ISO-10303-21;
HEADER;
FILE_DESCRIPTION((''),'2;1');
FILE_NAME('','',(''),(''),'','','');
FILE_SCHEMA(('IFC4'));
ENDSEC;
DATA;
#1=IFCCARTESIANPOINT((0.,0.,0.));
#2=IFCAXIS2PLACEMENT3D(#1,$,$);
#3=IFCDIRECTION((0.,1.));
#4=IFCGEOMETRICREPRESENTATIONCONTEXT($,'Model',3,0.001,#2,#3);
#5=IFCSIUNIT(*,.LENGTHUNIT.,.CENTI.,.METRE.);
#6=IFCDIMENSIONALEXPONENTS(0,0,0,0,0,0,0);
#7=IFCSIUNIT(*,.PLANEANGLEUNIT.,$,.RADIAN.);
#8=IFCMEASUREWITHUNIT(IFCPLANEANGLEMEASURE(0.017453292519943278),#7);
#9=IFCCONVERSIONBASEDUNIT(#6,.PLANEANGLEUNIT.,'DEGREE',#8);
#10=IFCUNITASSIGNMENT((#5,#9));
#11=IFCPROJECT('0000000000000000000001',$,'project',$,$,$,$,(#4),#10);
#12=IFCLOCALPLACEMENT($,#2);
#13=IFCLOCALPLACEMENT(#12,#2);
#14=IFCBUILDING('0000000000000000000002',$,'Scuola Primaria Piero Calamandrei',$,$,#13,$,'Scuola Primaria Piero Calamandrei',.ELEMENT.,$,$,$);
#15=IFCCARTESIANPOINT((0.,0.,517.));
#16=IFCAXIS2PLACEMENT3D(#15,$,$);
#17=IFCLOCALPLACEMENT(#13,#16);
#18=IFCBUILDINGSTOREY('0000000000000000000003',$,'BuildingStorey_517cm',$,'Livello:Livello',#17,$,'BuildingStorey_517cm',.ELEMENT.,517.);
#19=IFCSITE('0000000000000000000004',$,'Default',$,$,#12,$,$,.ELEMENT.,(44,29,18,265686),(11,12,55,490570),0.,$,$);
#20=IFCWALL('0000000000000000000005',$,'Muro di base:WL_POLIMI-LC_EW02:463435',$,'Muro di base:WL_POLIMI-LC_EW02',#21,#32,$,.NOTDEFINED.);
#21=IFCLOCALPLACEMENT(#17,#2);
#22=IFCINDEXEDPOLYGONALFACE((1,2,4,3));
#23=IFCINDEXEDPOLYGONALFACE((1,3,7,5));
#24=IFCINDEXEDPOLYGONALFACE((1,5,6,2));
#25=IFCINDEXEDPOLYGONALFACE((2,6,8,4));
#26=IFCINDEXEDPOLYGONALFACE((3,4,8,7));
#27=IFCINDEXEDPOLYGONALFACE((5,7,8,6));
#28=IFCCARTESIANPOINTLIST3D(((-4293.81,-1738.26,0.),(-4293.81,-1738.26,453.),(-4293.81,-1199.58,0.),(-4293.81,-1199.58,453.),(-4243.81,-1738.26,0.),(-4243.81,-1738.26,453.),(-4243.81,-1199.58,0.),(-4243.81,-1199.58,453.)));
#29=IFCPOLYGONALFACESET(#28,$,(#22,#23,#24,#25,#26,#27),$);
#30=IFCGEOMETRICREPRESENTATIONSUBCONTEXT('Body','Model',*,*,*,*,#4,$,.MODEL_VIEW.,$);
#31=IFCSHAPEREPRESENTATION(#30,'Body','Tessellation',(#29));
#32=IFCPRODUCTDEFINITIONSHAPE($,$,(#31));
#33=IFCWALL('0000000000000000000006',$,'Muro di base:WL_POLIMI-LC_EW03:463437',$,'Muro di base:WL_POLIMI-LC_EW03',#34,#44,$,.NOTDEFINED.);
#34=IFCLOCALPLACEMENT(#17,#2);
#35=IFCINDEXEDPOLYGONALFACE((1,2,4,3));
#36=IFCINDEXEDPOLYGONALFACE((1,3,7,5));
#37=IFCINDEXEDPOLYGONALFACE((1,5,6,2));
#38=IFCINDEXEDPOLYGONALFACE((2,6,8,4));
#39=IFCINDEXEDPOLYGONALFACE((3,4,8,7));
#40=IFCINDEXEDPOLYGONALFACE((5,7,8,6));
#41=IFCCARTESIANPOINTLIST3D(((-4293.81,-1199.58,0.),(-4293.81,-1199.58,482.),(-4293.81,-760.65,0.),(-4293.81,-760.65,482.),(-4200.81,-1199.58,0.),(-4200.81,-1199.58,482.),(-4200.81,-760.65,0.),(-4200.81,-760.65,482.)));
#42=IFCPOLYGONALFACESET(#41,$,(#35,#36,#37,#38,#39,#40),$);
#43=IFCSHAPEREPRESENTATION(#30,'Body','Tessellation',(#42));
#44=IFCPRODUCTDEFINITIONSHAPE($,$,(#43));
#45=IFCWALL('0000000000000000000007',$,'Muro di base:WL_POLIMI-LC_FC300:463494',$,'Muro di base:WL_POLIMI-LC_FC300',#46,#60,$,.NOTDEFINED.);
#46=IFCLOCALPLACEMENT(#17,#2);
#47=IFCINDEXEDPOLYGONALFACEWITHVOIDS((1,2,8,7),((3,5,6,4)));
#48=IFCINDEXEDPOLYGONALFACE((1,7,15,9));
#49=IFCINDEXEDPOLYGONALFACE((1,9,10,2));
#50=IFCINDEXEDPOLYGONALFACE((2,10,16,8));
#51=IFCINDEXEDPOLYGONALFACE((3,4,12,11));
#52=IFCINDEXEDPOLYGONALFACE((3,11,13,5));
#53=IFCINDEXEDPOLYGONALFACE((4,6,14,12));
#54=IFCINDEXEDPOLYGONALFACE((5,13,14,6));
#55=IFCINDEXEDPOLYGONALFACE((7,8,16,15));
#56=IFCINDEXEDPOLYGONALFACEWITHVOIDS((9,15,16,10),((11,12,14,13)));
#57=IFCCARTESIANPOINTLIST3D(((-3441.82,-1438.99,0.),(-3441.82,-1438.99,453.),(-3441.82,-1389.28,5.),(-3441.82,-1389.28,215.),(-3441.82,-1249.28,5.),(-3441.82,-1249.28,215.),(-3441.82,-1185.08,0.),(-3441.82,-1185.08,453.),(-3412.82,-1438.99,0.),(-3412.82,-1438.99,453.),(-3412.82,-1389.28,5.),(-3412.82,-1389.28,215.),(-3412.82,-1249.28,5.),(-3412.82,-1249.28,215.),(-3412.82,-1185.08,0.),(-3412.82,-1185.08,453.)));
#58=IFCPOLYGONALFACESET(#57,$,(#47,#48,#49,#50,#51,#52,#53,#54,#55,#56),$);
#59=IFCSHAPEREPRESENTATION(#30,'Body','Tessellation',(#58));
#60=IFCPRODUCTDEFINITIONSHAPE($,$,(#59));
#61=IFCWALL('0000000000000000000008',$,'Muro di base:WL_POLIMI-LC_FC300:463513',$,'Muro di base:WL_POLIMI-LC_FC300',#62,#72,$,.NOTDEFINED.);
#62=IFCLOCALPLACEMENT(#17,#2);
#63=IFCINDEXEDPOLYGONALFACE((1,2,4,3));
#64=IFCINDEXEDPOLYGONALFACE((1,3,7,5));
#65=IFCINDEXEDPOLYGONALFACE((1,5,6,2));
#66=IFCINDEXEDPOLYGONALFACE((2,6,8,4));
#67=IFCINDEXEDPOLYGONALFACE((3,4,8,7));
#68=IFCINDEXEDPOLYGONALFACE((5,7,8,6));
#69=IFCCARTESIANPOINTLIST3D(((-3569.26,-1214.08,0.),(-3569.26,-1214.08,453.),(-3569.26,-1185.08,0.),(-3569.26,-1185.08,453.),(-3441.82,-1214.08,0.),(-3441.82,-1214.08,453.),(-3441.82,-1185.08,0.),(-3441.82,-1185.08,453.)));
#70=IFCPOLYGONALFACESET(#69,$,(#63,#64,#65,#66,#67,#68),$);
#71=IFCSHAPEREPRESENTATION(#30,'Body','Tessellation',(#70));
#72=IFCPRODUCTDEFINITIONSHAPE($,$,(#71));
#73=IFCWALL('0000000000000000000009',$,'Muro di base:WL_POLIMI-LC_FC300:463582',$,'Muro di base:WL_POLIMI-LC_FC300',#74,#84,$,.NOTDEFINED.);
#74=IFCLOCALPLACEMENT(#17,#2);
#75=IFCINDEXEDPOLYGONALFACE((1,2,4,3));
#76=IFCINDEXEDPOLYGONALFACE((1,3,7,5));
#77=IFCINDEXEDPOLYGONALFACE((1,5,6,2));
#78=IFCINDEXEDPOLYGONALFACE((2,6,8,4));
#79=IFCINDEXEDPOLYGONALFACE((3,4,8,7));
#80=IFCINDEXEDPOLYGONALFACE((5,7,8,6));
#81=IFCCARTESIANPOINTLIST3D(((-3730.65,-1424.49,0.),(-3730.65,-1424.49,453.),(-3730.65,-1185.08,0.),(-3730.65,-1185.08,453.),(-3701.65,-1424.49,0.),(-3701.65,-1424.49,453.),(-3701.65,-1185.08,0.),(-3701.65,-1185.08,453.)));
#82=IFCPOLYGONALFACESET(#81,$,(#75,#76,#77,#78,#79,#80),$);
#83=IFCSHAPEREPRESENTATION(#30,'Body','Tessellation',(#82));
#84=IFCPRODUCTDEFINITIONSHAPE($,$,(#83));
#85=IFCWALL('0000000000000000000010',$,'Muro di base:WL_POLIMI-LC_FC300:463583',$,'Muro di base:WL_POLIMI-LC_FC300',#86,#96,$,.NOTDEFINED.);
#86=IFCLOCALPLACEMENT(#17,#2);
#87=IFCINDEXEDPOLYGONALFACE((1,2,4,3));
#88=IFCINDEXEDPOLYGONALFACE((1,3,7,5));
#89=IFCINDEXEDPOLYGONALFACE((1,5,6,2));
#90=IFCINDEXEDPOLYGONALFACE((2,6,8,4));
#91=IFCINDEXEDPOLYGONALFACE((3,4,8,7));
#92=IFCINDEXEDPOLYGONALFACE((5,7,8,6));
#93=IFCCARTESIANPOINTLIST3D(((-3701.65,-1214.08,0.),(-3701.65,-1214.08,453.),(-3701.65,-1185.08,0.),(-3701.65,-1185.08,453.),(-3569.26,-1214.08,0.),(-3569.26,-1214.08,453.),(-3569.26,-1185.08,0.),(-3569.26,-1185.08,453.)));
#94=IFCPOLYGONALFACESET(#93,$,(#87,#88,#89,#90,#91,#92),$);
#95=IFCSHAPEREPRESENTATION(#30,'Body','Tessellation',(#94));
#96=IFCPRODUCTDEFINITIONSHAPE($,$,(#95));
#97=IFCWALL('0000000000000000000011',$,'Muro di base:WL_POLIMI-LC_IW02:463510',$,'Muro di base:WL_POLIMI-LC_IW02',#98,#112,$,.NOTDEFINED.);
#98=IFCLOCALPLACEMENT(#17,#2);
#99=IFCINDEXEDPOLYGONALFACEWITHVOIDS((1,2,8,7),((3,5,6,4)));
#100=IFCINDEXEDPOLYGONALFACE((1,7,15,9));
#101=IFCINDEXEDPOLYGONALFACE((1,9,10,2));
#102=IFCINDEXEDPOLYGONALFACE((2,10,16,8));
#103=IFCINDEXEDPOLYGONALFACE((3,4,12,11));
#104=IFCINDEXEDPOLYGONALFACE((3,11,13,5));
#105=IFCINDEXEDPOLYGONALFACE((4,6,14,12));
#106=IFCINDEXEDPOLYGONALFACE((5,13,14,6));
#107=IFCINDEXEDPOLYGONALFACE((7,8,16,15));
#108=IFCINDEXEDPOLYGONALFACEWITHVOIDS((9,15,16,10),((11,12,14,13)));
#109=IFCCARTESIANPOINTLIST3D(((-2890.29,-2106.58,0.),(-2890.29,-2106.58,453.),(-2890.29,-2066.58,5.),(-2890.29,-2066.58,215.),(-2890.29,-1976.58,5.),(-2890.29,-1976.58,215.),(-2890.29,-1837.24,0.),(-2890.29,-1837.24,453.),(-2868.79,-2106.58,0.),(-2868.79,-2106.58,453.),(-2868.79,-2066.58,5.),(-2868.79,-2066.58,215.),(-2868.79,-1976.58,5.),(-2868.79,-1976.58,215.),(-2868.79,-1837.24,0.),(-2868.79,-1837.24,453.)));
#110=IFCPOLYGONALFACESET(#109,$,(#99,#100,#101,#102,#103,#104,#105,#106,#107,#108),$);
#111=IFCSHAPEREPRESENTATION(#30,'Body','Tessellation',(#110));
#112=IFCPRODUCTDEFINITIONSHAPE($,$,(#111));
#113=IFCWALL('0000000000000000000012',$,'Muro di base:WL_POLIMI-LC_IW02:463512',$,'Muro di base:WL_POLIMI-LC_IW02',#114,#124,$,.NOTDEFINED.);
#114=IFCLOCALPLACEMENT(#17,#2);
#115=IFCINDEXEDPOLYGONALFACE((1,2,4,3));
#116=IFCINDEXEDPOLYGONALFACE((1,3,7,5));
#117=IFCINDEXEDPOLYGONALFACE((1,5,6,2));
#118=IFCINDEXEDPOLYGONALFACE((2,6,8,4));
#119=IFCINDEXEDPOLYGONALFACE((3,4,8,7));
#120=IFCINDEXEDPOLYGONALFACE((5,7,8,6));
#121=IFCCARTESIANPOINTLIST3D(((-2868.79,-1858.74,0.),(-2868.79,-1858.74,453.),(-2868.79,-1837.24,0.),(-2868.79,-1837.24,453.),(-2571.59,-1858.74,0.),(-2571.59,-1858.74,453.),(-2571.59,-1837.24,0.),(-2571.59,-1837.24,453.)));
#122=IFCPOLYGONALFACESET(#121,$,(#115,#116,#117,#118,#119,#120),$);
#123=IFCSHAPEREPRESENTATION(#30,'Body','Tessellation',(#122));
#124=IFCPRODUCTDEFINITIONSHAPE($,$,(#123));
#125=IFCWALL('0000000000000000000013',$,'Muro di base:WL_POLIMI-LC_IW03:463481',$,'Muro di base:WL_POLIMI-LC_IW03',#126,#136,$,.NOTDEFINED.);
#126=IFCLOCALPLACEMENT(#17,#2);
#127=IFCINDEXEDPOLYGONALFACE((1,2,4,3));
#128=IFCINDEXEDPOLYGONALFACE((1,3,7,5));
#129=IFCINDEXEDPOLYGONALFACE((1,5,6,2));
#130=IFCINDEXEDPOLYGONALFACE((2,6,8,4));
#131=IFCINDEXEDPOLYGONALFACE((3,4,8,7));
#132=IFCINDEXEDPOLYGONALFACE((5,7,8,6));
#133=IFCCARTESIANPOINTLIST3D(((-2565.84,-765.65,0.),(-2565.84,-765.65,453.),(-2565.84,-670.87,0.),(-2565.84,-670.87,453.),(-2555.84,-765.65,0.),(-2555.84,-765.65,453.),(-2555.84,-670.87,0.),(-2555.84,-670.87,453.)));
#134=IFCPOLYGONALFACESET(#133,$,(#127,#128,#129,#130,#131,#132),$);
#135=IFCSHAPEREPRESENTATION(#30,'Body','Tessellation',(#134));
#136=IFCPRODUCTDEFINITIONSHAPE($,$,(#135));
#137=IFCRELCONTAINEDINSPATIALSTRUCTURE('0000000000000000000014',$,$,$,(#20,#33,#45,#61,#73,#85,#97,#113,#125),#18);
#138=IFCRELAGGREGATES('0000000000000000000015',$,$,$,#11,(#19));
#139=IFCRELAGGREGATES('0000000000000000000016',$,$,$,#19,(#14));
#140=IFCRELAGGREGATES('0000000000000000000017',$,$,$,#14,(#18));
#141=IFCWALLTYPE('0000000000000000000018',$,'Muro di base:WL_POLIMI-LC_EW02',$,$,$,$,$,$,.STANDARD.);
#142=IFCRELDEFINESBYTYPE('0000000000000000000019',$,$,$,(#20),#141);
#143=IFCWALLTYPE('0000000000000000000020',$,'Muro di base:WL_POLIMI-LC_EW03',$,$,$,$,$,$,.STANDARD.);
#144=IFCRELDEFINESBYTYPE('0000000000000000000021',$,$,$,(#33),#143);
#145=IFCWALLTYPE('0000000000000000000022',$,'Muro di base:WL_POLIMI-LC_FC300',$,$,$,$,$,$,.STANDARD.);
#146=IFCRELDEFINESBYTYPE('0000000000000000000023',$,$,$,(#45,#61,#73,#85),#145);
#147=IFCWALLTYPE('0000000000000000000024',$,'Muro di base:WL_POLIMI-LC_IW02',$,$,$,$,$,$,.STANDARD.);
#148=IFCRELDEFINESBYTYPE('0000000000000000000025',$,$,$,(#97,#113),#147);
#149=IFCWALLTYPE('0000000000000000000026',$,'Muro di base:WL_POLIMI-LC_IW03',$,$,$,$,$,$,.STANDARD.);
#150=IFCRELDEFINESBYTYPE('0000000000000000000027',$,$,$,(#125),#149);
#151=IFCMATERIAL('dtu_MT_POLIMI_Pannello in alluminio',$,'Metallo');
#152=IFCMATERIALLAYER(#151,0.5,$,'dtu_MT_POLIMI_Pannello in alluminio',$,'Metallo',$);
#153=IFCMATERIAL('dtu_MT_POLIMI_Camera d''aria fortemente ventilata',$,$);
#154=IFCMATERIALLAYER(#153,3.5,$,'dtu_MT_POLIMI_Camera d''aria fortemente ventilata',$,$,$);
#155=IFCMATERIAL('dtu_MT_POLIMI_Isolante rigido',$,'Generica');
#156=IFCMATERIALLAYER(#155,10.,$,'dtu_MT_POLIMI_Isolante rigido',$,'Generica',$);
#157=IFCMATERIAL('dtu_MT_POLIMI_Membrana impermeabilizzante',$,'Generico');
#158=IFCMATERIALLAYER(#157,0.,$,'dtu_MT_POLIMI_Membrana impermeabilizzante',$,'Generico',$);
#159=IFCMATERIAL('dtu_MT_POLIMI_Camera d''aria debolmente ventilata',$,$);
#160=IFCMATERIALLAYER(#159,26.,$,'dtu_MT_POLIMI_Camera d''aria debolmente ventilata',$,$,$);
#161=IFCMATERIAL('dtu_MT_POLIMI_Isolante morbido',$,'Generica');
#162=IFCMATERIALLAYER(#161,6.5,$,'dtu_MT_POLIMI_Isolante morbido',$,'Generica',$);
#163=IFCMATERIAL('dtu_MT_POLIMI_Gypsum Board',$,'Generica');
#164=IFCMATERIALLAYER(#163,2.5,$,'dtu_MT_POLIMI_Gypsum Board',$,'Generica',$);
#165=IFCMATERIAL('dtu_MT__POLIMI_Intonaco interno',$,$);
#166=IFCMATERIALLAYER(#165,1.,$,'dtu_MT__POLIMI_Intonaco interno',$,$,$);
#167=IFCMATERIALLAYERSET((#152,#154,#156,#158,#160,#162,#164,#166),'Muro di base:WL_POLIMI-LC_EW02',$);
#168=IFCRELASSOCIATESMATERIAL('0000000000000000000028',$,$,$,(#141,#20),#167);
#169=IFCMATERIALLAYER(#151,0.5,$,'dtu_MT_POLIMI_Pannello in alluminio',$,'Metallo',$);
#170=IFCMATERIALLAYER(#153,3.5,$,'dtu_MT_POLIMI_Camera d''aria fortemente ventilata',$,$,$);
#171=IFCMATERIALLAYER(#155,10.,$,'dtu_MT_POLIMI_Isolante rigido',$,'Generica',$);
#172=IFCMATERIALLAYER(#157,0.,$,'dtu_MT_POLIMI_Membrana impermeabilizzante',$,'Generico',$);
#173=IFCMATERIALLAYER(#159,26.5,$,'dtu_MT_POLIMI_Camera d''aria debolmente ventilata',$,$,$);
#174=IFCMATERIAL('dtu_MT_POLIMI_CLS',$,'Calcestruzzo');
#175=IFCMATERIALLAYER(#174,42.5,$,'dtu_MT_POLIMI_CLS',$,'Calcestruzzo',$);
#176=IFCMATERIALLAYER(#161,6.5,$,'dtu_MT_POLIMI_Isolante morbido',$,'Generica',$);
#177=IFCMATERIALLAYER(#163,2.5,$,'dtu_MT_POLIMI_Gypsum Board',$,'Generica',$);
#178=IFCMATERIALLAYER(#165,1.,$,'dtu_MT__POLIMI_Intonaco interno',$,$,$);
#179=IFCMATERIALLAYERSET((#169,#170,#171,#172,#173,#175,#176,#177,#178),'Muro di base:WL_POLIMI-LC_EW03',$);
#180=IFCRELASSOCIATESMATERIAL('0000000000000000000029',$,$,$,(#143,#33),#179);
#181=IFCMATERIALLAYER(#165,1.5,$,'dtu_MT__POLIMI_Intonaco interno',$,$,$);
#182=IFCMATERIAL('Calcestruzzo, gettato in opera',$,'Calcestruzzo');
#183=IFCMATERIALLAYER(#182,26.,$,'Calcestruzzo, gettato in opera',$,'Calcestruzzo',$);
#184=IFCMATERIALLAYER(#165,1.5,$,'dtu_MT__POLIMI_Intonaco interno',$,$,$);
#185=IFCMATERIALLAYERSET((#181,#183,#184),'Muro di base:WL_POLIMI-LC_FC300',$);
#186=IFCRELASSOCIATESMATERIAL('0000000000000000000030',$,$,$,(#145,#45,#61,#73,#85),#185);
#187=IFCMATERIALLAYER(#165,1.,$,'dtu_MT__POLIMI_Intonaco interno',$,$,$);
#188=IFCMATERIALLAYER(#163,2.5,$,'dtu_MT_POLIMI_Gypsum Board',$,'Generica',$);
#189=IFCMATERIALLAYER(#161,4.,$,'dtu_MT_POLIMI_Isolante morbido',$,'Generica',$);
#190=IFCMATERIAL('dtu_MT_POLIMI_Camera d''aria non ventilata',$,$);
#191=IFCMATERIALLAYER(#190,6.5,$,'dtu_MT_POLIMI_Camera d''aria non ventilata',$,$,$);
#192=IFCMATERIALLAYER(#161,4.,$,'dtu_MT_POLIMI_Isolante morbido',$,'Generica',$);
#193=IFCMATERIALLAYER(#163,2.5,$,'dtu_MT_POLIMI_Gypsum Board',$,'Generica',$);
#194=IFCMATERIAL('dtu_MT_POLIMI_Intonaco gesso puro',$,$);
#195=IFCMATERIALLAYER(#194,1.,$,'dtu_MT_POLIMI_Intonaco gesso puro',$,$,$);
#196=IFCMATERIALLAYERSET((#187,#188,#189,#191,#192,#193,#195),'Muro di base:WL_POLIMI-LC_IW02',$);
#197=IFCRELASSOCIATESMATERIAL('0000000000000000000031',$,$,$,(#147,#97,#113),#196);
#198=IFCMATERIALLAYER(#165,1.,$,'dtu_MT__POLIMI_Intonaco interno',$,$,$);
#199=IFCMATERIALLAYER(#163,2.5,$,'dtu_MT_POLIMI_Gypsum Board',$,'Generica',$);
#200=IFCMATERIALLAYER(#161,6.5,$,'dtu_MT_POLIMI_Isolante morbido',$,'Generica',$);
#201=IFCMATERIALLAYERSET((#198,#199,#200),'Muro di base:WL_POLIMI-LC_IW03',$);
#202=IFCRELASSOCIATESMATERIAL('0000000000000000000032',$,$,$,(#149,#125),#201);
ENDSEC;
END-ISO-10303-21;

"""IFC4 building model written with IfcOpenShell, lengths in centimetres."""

from ifc_helpers import new_model, entity, si_unit, converted_unit, direction, frame, frame_2d, origin, place, context, subcontext, project, spatial, polyline, rectangle, extrude, clip, bounded_halfspace, material, layer, layer_set, layer_usage, type_object, element, save


model = new_model("IFC4")

# Units and contexts
model_context = context("Model", 3, precision=0.001, world=origin(), true_north=direction((0.0, 1.0)))
body_context = subcontext(model_context, "Body", "Model", "MODEL_VIEW")
ifc_project = project(units=[si_unit("LENGTHUNIT", "METRE", prefix="CENTI"), converted_unit("PLANEANGLEUNIT", "DEGREE", entity("IfcPlaneAngleMeasure", 0.017453292519943278), si_unit("PLANEANGLEUNIT", "RADIAN"), dimensions=[0, 0, 0, 0, 0, 0, 0])], contexts=[model_context])

# Site, building, storey
site_placement = place(None, origin())
site = spatial("IfcSite", under=ifc_project, at=site_placement, Name="Default", CompositionType="ELEMENT", RefLatitude=(44, 29, 18, 265686), RefLongitude=(11, 12, 55, 490570), RefElevation=0.0)
building_placement = place(site_placement, origin())
building = spatial("IfcBuilding", under=site, at=building_placement, Name="Scuola Primaria Piero Calamandrei", LongName="Scuola Primaria Piero Calamandrei", CompositionType="ELEMENT")
storey_placement = place(building_placement, frame((0.0, 0.0, 517.0)))
storey = spatial("IfcBuildingStorey", under=building, at=storey_placement, Name="BuildingStorey_517cm", ObjectType="Livello:Livello", LongName="BuildingStorey_517cm", CompositionType="ELEMENT", Elevation=517.0)

# Walls
ifc_material_1 = material(Name="dtu_MT_POLIMI_Pannello in alluminio", Category="Metallo")
ifc_layer_1 = layer(ifc_material_1, 0.5, Name="dtu_MT_POLIMI_Pannello in alluminio", Category="Metallo")
ifc_material_2 = material(Name="dtu_MT_POLIMI_Camera d'aria fortemente ventilata")
ifc_layer_2 = layer(ifc_material_2, 3.5, Name="dtu_MT_POLIMI_Camera d'aria fortemente ventilata")
ifc_material_3 = material(Name="dtu_MT_POLIMI_Isolante rigido", Category="Generica")
ifc_layer_3 = layer(ifc_material_3, 10.0, Name="dtu_MT_POLIMI_Isolante rigido", Category="Generica")
ifc_material_4 = material(Name="dtu_MT_POLIMI_Membrana impermeabilizzante", Category="Generico")
ifc_layer_4 = layer(ifc_material_4, 0.0, Name="dtu_MT_POLIMI_Membrana impermeabilizzante", Category="Generico")
ifc_material_5 = material(Name="dtu_MT_POLIMI_Camera d'aria debolmente ventilata")
ifc_layer_5 = layer(ifc_material_5, 26.0, Name="dtu_MT_POLIMI_Camera d'aria debolmente ventilata")
ifc_material_6 = material(Name="dtu_MT_POLIMI_Isolante morbido", Category="Generica")
ifc_layer_6 = layer(ifc_material_6, 6.5, Name="dtu_MT_POLIMI_Isolante morbido", Category="Generica")
ifc_material_7 = material(Name="dtu_MT_POLIMI_Gypsum Board", Category="Generica")
ifc_layer_7 = layer(ifc_material_7, 2.5, Name="dtu_MT_POLIMI_Gypsum Board", Category="Generica")
ifc_material_8 = material(Name="dtu_MT__POLIMI_Intonaco interno")
ifc_layer_8 = layer(ifc_material_8, 1.0, Name="dtu_MT__POLIMI_Intonaco interno")
ifc_layer_set_1 = layer_set([ifc_layer_1, ifc_layer_2, ifc_layer_3, ifc_layer_4, ifc_layer_5, ifc_layer_6, ifc_layer_7, ifc_layer_8], Name="Muro di base:WL_POLIMI-LC_EW02")
ifc_layer_usage_1 = layer_usage(ifc_layer_set_1, "AXIS2", "NEGATIVE", 25.0)
wall_type_1 = type_object("IfcWallType", Name="Muro di base:WL_POLIMI-LC_EW02", PredefinedType="STANDARD", material=ifc_layer_set_1)
wall_1_placement = place(storey_placement, frame((-4268.81, -1738.26, 0.0), z_axis=(0.0, 0.0, 1.0), x_axis=(0.0, 1.0, 0.0)))
element("IfcWall", 1, at=wall_1_placement, inside=storey, type_object=wall_type_1, material=ifc_layer_usage_1, Name="Muro di base:WL_POLIMI-LC_EW02:463435", ObjectType="Muro di base:WL_POLIMI-LC_EW02", PredefinedType="NOTDEFINED", context=body_context, shape_type="Clipping", body=[
    clip(extrude(rectangle(XDim=538.68, YDim=50.0, at=frame_2d((269.34, 0.0), x_axis=(-1.0, 0.0))), origin(), (0.0, 0.0, 1.0), 453.0), bounded_halfspace(frame((0.0, -25.0, 453.0), z_axis=(0.0, 0.0, 1.0), x_axis=(0.0, -1.0, 0.0)), False, frame((0.0, -25.0, 453.0)), polyline([(0.0, 0.0), (12.25, 0.0), (516.93, 0.0), (538.68, 0.0), (538.68, 50.0), (0.0, 50.0), (0.0, 0.0)]))),
])
ifc_layer_9 = layer(ifc_material_1, 0.5, Name="dtu_MT_POLIMI_Pannello in alluminio", Category="Metallo")
ifc_layer_10 = layer(ifc_material_2, 3.5, Name="dtu_MT_POLIMI_Camera d'aria fortemente ventilata")
ifc_layer_11 = layer(ifc_material_3, 10.0, Name="dtu_MT_POLIMI_Isolante rigido", Category="Generica")
ifc_layer_12 = layer(ifc_material_4, 0.0, Name="dtu_MT_POLIMI_Membrana impermeabilizzante", Category="Generico")
ifc_layer_13 = layer(ifc_material_5, 26.5, Name="dtu_MT_POLIMI_Camera d'aria debolmente ventilata")
ifc_material_9 = material(Name="dtu_MT_POLIMI_CLS", Category="Calcestruzzo")
ifc_layer_14 = layer(ifc_material_9, 42.5, Name="dtu_MT_POLIMI_CLS", Category="Calcestruzzo")
ifc_layer_15 = layer(ifc_material_6, 6.5, Name="dtu_MT_POLIMI_Isolante morbido", Category="Generica")
ifc_layer_16 = layer(ifc_material_7, 2.5, Name="dtu_MT_POLIMI_Gypsum Board", Category="Generica")
ifc_layer_17 = layer(ifc_material_8, 1.0, Name="dtu_MT__POLIMI_Intonaco interno")
ifc_layer_set_2 = layer_set([ifc_layer_9, ifc_layer_10, ifc_layer_11, ifc_layer_12, ifc_layer_13, ifc_layer_14, ifc_layer_15, ifc_layer_16, ifc_layer_17], Name="Muro di base:WL_POLIMI-LC_EW03")
ifc_layer_usage_2 = layer_usage(ifc_layer_set_2, "AXIS2", "NEGATIVE", 46.5)
wall_type_2 = type_object("IfcWallType", Name="Muro di base:WL_POLIMI-LC_EW03", PredefinedType="STANDARD", material=ifc_layer_set_2)
wall_2_placement = place(storey_placement, frame((-4247.31, -1199.58, 0.0), z_axis=(0.0, 0.0, 1.0), x_axis=(0.0, 1.0, 0.0)))
element("IfcWall", 2, at=wall_2_placement, inside=storey, type_object=wall_type_2, material=ifc_layer_usage_2, Name="Muro di base:WL_POLIMI-LC_EW03:463437", ObjectType="Muro di base:WL_POLIMI-LC_EW03", PredefinedType="NOTDEFINED", context=body_context, shape_type="Clipping", body=[
    clip(extrude(rectangle(XDim=438.92, YDim=93.0, at=frame_2d((219.46, 0.0), x_axis=(-1.0, 0.0))), origin(), (0.0, 0.0, 1.0), 482.0), bounded_halfspace(frame((0.0, -46.5, 482.0), z_axis=(0.0, 0.0, -1.0), x_axis=(0.0, 1.0, 0.0)), True, frame((0.0, -46.5, 482.0)), polyline([(0.0, 0.0), (438.92, 0.0), (438.92, 93.0), (0.0, 93.0), (0.0, 0.0)]))),
])

# Wall, opening
ifc_layer_18 = layer(ifc_material_8, 1.5, Name="dtu_MT__POLIMI_Intonaco interno")
ifc_material_10 = material(Name="Calcestruzzo, gettato in opera", Category="Calcestruzzo")
ifc_layer_19 = layer(ifc_material_10, 26.0, Name="Calcestruzzo, gettato in opera", Category="Calcestruzzo")
ifc_layer_20 = layer(ifc_material_8, 1.5, Name="dtu_MT__POLIMI_Intonaco interno")
ifc_layer_set_3 = layer_set([ifc_layer_18, ifc_layer_19, ifc_layer_20], Name="Muro di base:WL_POLIMI-LC_FC300")
ifc_layer_usage_3 = layer_usage(ifc_layer_set_3, "AXIS2", "NEGATIVE", 14.5)
wall_type_3 = type_object("IfcWallType", Name="Muro di base:WL_POLIMI-LC_FC300", PredefinedType="STANDARD", material=ifc_layer_set_3)
wall_3_placement = place(storey_placement, frame((-3427.32, -1438.99, 0.0), z_axis=(0.0, 0.0, 1.0), x_axis=(0.0, 1.0, 0.0)))
wall_3 = element("IfcWall", 3, at=wall_3_placement, inside=storey, type_object=wall_type_3, material=ifc_layer_usage_3, Name="Muro di base:WL_POLIMI-LC_FC300:463494", ObjectType="Muro di base:WL_POLIMI-LC_FC300", PredefinedType="NOTDEFINED", context=body_context, shape_type="SweptSolid", body=[
    extrude(rectangle(XDim=253.91, YDim=29.0, at=frame_2d((126.96, 0.0), x_axis=(-1.0, 0.0))), origin(), (0.0, 0.0, 1.0), 453.0),
])
opening_1_placement = place(wall_3_placement, frame((49.71, -14.5, 5.0)))
element("IfcOpeningElement", 4, at=opening_1_placement, cuts=wall_3, PredefinedType="OPENING", context=body_context, shape_type="SweptSolid", body=[
    extrude(rectangle(XDim=210.0, YDim=140.0, at=frame_2d((105.0, 70.0), x_axis=(1.0, 0.0))), frame((0.0, 0.0, 0.0), z_axis=(0.0, 1.0, 0.0), x_axis=(0.0, 0.0, 1.0)), (0.0, 0.0, 1.0), 29.0),
])

# Walls
ifc_layer_usage_4 = layer_usage(ifc_layer_set_3, "AXIS2", "NEGATIVE", 14.5)
wall_4_placement = place(storey_placement, frame((-3441.82, -1199.58, 0.0), z_axis=(0.0, 0.0, 1.0), x_axis=(-1.0, 0.0, 0.0)))
element("IfcWall", 5, at=wall_4_placement, inside=storey, type_object=wall_type_3, material=ifc_layer_usage_4, Name="Muro di base:WL_POLIMI-LC_FC300:463513", ObjectType="Muro di base:WL_POLIMI-LC_FC300", PredefinedType="NOTDEFINED", context=body_context, shape_type="SweptSolid", body=[
    extrude(rectangle(XDim=127.43, YDim=29.0, at=frame_2d((63.72, 0.0), x_axis=(-1.0, 0.0))), origin(), (0.0, 0.0, 1.0), 453.0),
])
ifc_layer_usage_5 = layer_usage(ifc_layer_set_3, "AXIS2", "NEGATIVE", 14.5)
wall_5_placement = place(storey_placement, frame((-3716.15, -1424.49, 0.0), z_axis=(0.0, 0.0, 1.0), x_axis=(0.0, 1.0, 0.0)))
element("IfcWall", 6, at=wall_5_placement, inside=storey, type_object=wall_type_3, material=ifc_layer_usage_5, Name="Muro di base:WL_POLIMI-LC_FC300:463582", ObjectType="Muro di base:WL_POLIMI-LC_FC300", PredefinedType="NOTDEFINED", context=body_context, shape_type="SweptSolid", body=[
    extrude(rectangle(XDim=239.41, YDim=29.0, at=frame_2d((119.71, 0.0), x_axis=(-1.0, 0.0))), origin(), (0.0, 0.0, 1.0), 453.0),
])
ifc_layer_usage_6 = layer_usage(ifc_layer_set_3, "AXIS2", "NEGATIVE", 14.5)
wall_6_placement = place(storey_placement, frame((-3701.65, -1199.58, 0.0)))
element("IfcWall", 7, at=wall_6_placement, inside=storey, type_object=wall_type_3, material=ifc_layer_usage_6, Name="Muro di base:WL_POLIMI-LC_FC300:463583", ObjectType="Muro di base:WL_POLIMI-LC_FC300", PredefinedType="NOTDEFINED", context=body_context, shape_type="SweptSolid", body=[
    extrude(rectangle(XDim=132.39, YDim=29.0, at=frame_2d((66.2, 0.0), x_axis=(-1.0, 0.0))), origin(), (0.0, 0.0, 1.0), 453.0),
])

# Wall, opening
ifc_layer_21 = layer(ifc_material_8, 1.0, Name="dtu_MT__POLIMI_Intonaco interno")
ifc_layer_22 = layer(ifc_material_7, 2.5, Name="dtu_MT_POLIMI_Gypsum Board", Category="Generica")
ifc_layer_23 = layer(ifc_material_6, 4.0, Name="dtu_MT_POLIMI_Isolante morbido", Category="Generica")
ifc_material_11 = material(Name="dtu_MT_POLIMI_Camera d'aria non ventilata")
ifc_layer_24 = layer(ifc_material_11, 6.5, Name="dtu_MT_POLIMI_Camera d'aria non ventilata")
ifc_layer_25 = layer(ifc_material_6, 4.0, Name="dtu_MT_POLIMI_Isolante morbido", Category="Generica")
ifc_layer_26 = layer(ifc_material_7, 2.5, Name="dtu_MT_POLIMI_Gypsum Board", Category="Generica")
ifc_material_12 = material(Name="dtu_MT_POLIMI_Intonaco gesso puro")
ifc_layer_27 = layer(ifc_material_12, 1.0, Name="dtu_MT_POLIMI_Intonaco gesso puro")
ifc_layer_set_4 = layer_set([ifc_layer_21, ifc_layer_22, ifc_layer_23, ifc_layer_24, ifc_layer_25, ifc_layer_26, ifc_layer_27], Name="Muro di base:WL_POLIMI-LC_IW02")
ifc_layer_usage_7 = layer_usage(ifc_layer_set_4, "AXIS2", "NEGATIVE", 10.75)
wall_type_4 = type_object("IfcWallType", Name="Muro di base:WL_POLIMI-LC_IW02", PredefinedType="STANDARD", material=ifc_layer_set_4)
wall_7_placement = place(storey_placement, frame((-2879.54, -1837.24, 0.0), z_axis=(0.0, 0.0, 1.0), x_axis=(0.0, -1.0, 0.0)))
wall_7 = element("IfcWall", 8, at=wall_7_placement, inside=storey, type_object=wall_type_4, material=ifc_layer_usage_7, Name="Muro di base:WL_POLIMI-LC_IW02:463510", ObjectType="Muro di base:WL_POLIMI-LC_IW02", PredefinedType="NOTDEFINED", context=body_context, shape_type="SweptSolid", body=[
    extrude(rectangle(XDim=269.34, YDim=21.5, at=frame_2d((134.67, 0.0), x_axis=(-1.0, 0.0))), origin(), (0.0, 0.0, 1.0), 453.0),
])
opening_2_placement = place(wall_7_placement, frame((139.34, -10.75, 5.0)))
element("IfcOpeningElement", 9, at=opening_2_placement, cuts=wall_7, PredefinedType="OPENING", context=body_context, shape_type="SweptSolid", body=[
    extrude(rectangle(XDim=210.0, YDim=90.0, at=frame_2d((105.0, 45.0), x_axis=(1.0, 0.0))), frame((0.0, 0.0, 0.0), z_axis=(0.0, 1.0, 0.0), x_axis=(0.0, 0.0, 1.0)), (0.0, 0.0, 1.0), 21.5),
])

# Walls
ifc_layer_usage_8 = layer_usage(ifc_layer_set_4, "AXIS2", "NEGATIVE", 10.75)
wall_8_placement = place(storey_placement, frame((-2571.59, -1847.99, 0.0), z_axis=(0.0, 0.0, 1.0), x_axis=(-1.0, 0.0, 0.0)))
element("IfcWall", 10, at=wall_8_placement, inside=storey, type_object=wall_type_4, material=ifc_layer_usage_8, Name="Muro di base:WL_POLIMI-LC_IW02:463512", ObjectType="Muro di base:WL_POLIMI-LC_IW02", PredefinedType="NOTDEFINED", context=body_context, shape_type="SweptSolid", body=[
    extrude(rectangle(XDim=297.21, YDim=21.5, at=frame_2d((148.6, 0.0), x_axis=(-1.0, 0.0))), origin(), (0.0, 0.0, 1.0), 453.0),
])
ifc_layer_28 = layer(ifc_material_8, 1.0, Name="dtu_MT__POLIMI_Intonaco interno")
ifc_layer_29 = layer(ifc_material_7, 2.5, Name="dtu_MT_POLIMI_Gypsum Board", Category="Generica")
ifc_layer_30 = layer(ifc_material_6, 6.5, Name="dtu_MT_POLIMI_Isolante morbido", Category="Generica")
ifc_layer_set_5 = layer_set([ifc_layer_28, ifc_layer_29, ifc_layer_30], Name="Muro di base:WL_POLIMI-LC_IW03")
ifc_layer_usage_9 = layer_usage(ifc_layer_set_5, "AXIS2", "NEGATIVE", 5.0)
wall_type_5 = type_object("IfcWallType", Name="Muro di base:WL_POLIMI-LC_IW03", PredefinedType="STANDARD", material=ifc_layer_set_5)
wall_9_placement = place(storey_placement, frame((-2560.84, -765.65, 0.0), z_axis=(0.0, 0.0, 1.0), x_axis=(0.0, 1.0, 0.0)))
element("IfcWall", 11, at=wall_9_placement, inside=storey, type_object=wall_type_5, material=ifc_layer_usage_9, Name="Muro di base:WL_POLIMI-LC_IW03:463481", ObjectType="Muro di base:WL_POLIMI-LC_IW03", PredefinedType="NOTDEFINED", context=body_context, shape_type="SweptSolid", body=[
    extrude(rectangle(XDim=94.78, YDim=10.0, at=frame_2d((47.39, 0.0), x_axis=(-1.0, 0.0))), origin(), (0.0, 0.0, 1.0), 453.0),
])

save(model, "model.ifc")
